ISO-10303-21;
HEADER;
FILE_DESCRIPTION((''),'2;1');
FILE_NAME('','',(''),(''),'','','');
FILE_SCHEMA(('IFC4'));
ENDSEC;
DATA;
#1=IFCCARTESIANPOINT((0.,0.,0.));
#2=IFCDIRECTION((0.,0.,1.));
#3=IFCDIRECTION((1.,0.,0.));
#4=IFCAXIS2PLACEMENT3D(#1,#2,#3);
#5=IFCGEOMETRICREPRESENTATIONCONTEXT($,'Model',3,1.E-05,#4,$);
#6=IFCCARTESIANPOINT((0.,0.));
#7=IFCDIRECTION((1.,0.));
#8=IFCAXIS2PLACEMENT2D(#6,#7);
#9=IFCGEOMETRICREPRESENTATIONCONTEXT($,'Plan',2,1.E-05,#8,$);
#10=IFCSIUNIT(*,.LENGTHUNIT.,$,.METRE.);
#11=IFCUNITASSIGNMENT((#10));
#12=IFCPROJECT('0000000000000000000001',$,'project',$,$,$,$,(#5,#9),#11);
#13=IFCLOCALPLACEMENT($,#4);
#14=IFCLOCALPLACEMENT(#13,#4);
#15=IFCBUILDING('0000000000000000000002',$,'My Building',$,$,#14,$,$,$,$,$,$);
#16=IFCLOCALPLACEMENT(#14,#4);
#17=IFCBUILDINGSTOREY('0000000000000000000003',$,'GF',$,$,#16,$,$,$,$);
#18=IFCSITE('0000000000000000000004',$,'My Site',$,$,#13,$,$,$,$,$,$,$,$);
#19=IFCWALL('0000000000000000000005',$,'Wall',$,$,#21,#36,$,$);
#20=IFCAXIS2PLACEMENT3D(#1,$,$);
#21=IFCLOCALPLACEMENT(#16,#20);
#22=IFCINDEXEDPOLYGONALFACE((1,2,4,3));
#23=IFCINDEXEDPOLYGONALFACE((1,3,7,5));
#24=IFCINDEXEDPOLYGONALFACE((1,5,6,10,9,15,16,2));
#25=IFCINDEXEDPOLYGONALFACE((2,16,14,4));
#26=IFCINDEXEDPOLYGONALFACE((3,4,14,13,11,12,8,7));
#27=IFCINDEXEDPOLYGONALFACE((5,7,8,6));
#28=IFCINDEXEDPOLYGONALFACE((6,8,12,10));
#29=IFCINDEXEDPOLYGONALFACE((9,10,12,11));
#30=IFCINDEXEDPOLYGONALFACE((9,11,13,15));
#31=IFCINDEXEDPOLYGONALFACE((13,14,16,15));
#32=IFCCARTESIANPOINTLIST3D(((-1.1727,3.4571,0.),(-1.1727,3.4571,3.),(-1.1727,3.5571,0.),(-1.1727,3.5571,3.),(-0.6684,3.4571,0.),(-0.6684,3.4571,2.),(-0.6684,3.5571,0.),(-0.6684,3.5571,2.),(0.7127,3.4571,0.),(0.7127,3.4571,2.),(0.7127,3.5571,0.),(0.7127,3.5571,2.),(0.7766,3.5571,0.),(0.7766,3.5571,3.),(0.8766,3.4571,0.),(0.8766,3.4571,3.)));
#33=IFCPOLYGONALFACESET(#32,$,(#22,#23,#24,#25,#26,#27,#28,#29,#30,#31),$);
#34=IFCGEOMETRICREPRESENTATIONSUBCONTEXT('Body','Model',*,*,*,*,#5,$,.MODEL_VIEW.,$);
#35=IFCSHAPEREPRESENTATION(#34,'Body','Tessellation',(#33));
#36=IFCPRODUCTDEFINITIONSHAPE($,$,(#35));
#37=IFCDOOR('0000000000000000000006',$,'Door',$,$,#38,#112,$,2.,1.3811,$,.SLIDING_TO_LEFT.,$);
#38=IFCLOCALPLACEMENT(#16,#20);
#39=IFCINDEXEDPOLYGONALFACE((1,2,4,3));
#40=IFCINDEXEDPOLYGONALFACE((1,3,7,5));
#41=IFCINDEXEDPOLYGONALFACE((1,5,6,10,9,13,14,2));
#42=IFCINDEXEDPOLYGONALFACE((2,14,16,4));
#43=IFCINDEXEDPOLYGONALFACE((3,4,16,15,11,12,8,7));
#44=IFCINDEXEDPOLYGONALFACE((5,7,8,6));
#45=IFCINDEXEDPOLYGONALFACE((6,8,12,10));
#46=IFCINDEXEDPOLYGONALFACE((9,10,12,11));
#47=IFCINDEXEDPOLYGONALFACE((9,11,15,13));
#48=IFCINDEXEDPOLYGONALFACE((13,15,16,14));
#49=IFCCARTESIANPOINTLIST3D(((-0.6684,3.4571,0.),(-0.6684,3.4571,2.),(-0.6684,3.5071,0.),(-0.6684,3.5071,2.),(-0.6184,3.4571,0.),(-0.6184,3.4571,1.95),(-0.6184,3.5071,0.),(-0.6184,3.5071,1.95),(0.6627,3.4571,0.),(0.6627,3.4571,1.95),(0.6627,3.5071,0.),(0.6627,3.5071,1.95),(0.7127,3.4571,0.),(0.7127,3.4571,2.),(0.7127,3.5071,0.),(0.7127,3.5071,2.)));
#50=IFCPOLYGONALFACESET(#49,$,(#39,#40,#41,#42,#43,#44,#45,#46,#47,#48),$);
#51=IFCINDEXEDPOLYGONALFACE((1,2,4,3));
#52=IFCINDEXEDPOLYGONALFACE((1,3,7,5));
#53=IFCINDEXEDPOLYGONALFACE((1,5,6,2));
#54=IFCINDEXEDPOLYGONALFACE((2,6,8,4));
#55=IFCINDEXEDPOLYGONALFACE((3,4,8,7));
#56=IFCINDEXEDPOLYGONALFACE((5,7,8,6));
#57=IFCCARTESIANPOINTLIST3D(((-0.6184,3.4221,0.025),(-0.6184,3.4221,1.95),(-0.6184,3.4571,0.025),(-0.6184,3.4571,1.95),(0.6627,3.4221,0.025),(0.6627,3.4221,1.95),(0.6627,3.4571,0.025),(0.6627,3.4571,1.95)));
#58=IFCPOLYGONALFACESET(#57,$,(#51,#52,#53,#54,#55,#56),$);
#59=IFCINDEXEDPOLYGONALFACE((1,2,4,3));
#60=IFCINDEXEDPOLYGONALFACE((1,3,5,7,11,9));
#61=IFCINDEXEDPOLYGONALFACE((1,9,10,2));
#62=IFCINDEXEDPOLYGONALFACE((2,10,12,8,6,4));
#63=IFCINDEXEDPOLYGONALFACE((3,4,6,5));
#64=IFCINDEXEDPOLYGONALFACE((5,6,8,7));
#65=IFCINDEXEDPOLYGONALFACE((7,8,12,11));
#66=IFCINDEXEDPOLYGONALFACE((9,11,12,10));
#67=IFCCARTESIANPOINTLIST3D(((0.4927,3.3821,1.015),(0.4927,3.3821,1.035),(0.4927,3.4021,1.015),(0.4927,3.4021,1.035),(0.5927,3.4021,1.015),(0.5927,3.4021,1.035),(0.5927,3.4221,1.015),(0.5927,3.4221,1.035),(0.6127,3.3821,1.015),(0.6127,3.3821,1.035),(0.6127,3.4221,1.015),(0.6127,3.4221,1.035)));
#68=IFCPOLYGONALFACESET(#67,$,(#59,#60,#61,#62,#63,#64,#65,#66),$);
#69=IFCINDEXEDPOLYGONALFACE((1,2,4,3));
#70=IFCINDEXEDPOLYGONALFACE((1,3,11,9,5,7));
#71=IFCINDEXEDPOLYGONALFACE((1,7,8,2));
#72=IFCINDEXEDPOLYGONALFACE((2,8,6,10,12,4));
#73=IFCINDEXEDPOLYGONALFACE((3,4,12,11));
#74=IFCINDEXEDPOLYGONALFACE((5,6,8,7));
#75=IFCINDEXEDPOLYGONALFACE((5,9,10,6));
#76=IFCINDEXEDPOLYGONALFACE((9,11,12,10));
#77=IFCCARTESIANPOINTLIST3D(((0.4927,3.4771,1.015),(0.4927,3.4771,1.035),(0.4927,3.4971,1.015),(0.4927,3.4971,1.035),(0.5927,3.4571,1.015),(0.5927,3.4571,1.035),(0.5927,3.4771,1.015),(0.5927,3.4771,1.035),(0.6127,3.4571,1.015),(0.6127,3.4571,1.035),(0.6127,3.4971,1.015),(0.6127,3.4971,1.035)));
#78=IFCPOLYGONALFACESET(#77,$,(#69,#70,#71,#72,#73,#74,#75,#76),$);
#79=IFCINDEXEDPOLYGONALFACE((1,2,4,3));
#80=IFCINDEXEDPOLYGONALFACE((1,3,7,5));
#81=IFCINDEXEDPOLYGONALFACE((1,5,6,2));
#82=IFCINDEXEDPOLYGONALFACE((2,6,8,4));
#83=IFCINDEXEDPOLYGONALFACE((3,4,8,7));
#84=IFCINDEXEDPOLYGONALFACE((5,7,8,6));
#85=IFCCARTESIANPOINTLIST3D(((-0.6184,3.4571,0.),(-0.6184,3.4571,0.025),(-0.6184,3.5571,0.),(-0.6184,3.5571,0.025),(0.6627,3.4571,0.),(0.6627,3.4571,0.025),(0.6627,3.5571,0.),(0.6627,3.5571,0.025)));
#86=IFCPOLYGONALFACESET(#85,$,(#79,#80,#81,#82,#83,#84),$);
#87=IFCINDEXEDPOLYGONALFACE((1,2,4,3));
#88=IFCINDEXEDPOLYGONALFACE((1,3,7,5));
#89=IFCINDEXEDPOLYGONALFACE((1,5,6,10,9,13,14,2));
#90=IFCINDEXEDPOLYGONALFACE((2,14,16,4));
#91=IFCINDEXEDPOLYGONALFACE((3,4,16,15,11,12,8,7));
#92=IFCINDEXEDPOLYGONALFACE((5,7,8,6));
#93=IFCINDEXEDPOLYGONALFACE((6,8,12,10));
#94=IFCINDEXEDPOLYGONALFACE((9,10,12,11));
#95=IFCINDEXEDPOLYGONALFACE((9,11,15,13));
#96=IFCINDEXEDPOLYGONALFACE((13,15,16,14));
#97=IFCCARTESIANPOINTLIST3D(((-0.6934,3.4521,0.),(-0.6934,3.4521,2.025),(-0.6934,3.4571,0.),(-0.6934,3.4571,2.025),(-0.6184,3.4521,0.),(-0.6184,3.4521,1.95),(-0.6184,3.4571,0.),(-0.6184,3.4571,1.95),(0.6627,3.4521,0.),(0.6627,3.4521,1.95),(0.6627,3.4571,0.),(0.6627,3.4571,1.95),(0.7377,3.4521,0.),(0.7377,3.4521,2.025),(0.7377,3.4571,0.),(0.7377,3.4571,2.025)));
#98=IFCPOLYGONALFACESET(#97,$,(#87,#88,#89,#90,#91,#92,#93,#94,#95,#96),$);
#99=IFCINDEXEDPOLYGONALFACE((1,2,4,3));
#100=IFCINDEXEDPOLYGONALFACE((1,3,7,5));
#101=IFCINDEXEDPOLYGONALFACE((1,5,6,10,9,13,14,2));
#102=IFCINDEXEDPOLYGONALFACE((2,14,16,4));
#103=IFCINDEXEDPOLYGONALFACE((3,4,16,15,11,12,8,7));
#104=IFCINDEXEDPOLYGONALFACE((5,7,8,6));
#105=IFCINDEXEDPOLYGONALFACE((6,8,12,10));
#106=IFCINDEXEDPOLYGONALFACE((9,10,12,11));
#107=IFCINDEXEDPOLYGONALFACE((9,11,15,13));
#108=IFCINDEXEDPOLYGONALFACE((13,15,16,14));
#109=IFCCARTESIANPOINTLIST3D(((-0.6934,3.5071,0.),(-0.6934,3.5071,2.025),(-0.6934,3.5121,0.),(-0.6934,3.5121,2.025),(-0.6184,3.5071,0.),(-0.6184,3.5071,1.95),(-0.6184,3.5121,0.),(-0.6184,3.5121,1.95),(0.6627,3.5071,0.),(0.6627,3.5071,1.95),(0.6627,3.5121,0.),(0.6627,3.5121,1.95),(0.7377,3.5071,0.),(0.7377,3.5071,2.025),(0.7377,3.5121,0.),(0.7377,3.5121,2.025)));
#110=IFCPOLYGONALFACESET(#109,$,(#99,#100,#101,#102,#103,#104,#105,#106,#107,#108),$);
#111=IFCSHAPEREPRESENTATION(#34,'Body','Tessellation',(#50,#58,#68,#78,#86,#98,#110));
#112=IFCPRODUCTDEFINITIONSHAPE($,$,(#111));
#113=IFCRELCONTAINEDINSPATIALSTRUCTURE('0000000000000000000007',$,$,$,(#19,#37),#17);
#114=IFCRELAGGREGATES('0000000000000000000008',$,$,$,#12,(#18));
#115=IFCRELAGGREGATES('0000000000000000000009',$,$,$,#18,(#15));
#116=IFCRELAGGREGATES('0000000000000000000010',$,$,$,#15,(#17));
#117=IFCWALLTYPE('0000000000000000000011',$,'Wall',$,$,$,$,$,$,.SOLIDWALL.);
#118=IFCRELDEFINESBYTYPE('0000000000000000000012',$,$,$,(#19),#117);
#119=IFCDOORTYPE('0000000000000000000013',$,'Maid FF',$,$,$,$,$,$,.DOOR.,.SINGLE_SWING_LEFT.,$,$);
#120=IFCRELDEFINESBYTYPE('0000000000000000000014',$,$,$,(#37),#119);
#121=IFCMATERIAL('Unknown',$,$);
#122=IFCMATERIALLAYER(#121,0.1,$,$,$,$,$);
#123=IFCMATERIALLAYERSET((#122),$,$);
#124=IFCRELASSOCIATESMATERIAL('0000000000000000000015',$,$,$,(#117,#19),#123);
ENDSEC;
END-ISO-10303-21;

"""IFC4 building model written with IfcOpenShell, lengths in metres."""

from ifc_helpers import new_model, entity, si_unit, frame, origin_with_axes, origin_2d_with_axis, place, context, subcontext, project, spatial, line, indexed_curve, outline, extrude, shape, source, transform, mapped, material, layer, layer_set, layer_usage, type_object, type_shapes, element, fill, save


model = new_model("IFC4")

# Units and contexts
model_context = context("Model", 3, precision=1e-05, world=origin_with_axes())
plan_context = context("Plan", 2, precision=1e-05, world=origin_2d_with_axis())
body_context_1 = subcontext(model_context, "Body", "Model", "MODEL_VIEW")
body_context_2 = subcontext(plan_context, "Body", "Plan", "PLAN_VIEW")
ifc_project = project(units=[si_unit("LENGTHUNIT", "METRE")], contexts=[model_context, plan_context])

# Site, building, storey
site_placement = place(None, origin_with_axes())
site = spatial("IfcSite", under=ifc_project, at=site_placement, Name="My Site")
building_placement = place(site_placement, origin_with_axes())
building = spatial("IfcBuilding", under=site, at=building_placement, Name="My Building")
storey_placement = place(building_placement, origin_with_axes())
storey = spatial("IfcBuildingStorey", under=building, at=storey_placement, Name="GF")

# Shared definitions
ifc_material = material(Name="Unknown")
ifc_layer = layer(ifc_material, 0.1)
ifc_layer_set = layer_set([ifc_layer])
wall_type = type_object("IfcWallType", Name="Wall", PredefinedType="SOLIDWALL", material=ifc_layer_set)

# Wall, opening, door
ifc_layer_usage_1 = layer_usage(ifc_layer_set, "AXIS2", "POSITIVE", 0.0)
wall_1_placement = place(storey_placement, frame((0.7766, 3.5571, 0.0), z_axis=(0.0, 0.0, 1.0), x_axis=(-1.0, 0.0, 0.0)))
wall_1 = element("IfcWall", 1, at=wall_1_placement, inside=storey, type_object=wall_type, material=ifc_layer_usage_1, Name="Wall", context=body_context_1, shape_type="SweptSolid", body=[
    extrude(outline(indexed_curve([(0.0, 0.0), (-0.1, 0.1), (1.9493, 0.1), (1.9493, 0.0)], segments=[line(1, 2, 3, 4, 1)])), origin_with_axes(), (0.0, 0.0, 1.0), 3.0),
])
shared_shape_1 = source(origin_with_axes(), body_context_1, "Body", "SweptSolid", [
    extrude(outline(indexed_curve([(0.0, 0.0), (1.3811, 0.0), (1.3811, 2.0), (0.0, 2.0)], segments=[line(1, 2, 3, 4, 1)])), frame((0.0, -0.6, 0.0), z_axis=(0.0, -1.0, 0.0), x_axis=(1.0, 0.0, 0.0)), (0.0, 0.0, -1.0), 1.2),
])
opening_1_placement = place(wall_1_placement, frame((1.445, 0.1, 0.0), z_axis=(0.0, 0.0, 1.0), x_axis=(-1.0, 0.000001, 0.0)))
opening_1 = element("IfcOpeningElement", 2, at=opening_1_placement, cuts=wall_1, PredefinedType="OPENING", context=body_context_1, shape_type="MappedRepresentation", body=[
    mapped(shared_shape_1, transform((0.0, 0.0, 0.0), x_axis=(1.0, 0.0, 0.0), y_axis=(0.0, 1.0, 0.0), z_axis=(0.0, 0.0, 1.0), scale=1.0)),
])
door_type_1 = type_object("IfcDoorType", Name="Maid FF", OperationType="SINGLE_SWING_LEFT", PredefinedType="DOOR")
shared_shape_2 = source(origin_with_axes(), body_context_1, "Body", "SweptSolid", [
    extrude(outline(indexed_curve([(0.0, 0.0), (0.0, 2.0), (1.3811, 2.0), (1.3811, 0.0), (1.3311, 0.0), (1.3311, 1.95), (0.05, 1.95), (0.05, 0.0)], segments=[line(1, 2, 3, 4, 5, 6, 7, 8, 1)])), frame((0.0, 0.0, 0.0), z_axis=(0.0, -1.0, 0.0), x_axis=(1.0, 0.0, 0.0)), (0.0, 0.0, -1.0), 0.05),
    extrude(outline(indexed_curve([(0.0, 0.0), (1.2811, 0.0), (1.2811, 0.035), (0.0, 0.035)], segments=[line(1, 2, 3, 4, 1)])), frame((0.05, -0.035, 0.025), z_axis=(0.0, 0.0, 1.0), x_axis=(1.0, 0.0, 0.0)), (0.0, 0.0, 1.0), 1.925),
    extrude(outline(indexed_curve([(0.0, 0.0), (0.0, -0.04), (-0.12, -0.04), (-0.12, -0.02), (-0.02, -0.02), (-0.02, 0.0)], segments=[line(1, 2, 3, 4, 5, 6, 1)])), frame((1.2811, -0.035, 1.015), z_axis=(0.0, 0.0, 1.0), x_axis=(1.0, 0.0, 0.0)), (0.0, 0.0, 1.0), 0.02),
    extrude(outline(indexed_curve([(0.0, 0.0), (0.0, 0.04), (-0.12, 0.04), (-0.12, 0.02), (-0.02, 0.02), (-0.02, 0.0)], segments=[line(1, 2, 3, 4, 5, 6, 1)])), frame((1.2811, 0.0, 1.015), z_axis=(0.0, 0.0, 1.0), x_axis=(1.0, 0.0, 0.0)), (0.0, 0.0, 1.0), 0.02),
    extrude(outline(indexed_curve([(0.0, 0.0), (1.2811, 0.0), (1.2811, 0.1), (0.0, 0.1)], segments=[line(1, 2, 3, 4, 1)])), frame((0.05, 0.0, 0.0), z_axis=(0.0, 0.0, 1.0), x_axis=(1.0, 0.0, 0.0)), (0.0, 0.0, 1.0), 0.025),
    extrude(outline(indexed_curve([(0.0, 0.0), (0.0, 2.025), (1.4311, 2.025), (1.4311, 0.0), (1.3561, 0.0), (1.3561, 1.95), (0.075, 1.95), (0.075, 0.0)], segments=[line(1, 2, 3, 4, 5, 6, 7, 8, 1)])), frame((-0.025, -0.005, 0.0), z_axis=(0.0, -1.0, 0.0), x_axis=(1.0, 0.0, 0.0)), (0.0, 0.0, -1.0), 0.005),
    extrude(outline(indexed_curve([(0.0, 0.0), (0.0, 2.025), (1.4311, 2.025), (1.4311, 0.0), (1.3561, 0.0), (1.3561, 1.95), (0.075, 1.95), (0.075, 0.0)], segments=[line(1, 2, 3, 4, 5, 6, 7, 8, 1)])), frame((-0.025, 0.05, 0.0), z_axis=(0.0, -1.0, 0.0), x_axis=(1.0, 0.0, 0.0)), (0.0, 0.0, -1.0), 0.005),
])
shared_shape_3 = source(origin_with_axes(), body_context_2, "Body", "Curve2D", [
    entity("IfcIndexedPolyCurve", entity("IfcCartesianPointList2D", [[0.0, 0.0], [0.05, 0.0], [0.05, 0.05], [0.0, 0.05]]), [entity("IfcLineIndex", [1, 2, 3, 4, 1])]),
    entity("IfcIndexedPolyCurve", entity("IfcCartesianPointList2D", [[1.3811, 0.0], [1.3311, 0.0], [1.3311, 0.05], [1.3811, 0.05]]), [entity("IfcLineIndex", [1, 2, 3, 4, 1])]),
    entity("IfcIndexedPolyCurve", entity("IfcCartesianPointList2D", [[-0.5906, -0.035], [0.6906, -0.035], [0.6906, 0.0], [-0.5906, 0.0]]), [entity("IfcLineIndex", [1, 2, 3, 4, 1])]),
])
type_shapes(door_type_1, [shared_shape_2, shared_shape_3])
door_1_placement = place(opening_1_placement, frame((0.0, 0.0, 0.0), z_axis=(0.0, 0.0, 1.0), x_axis=(1.0, 0.0, 0.0)))
door_1 = element("IfcDoor", 3, at=door_1_placement, inside=storey, type_object=door_type_1, Name="Door", OperationType="SLIDING_TO_LEFT", OverallHeight=2.0, OverallWidth=1.3811, shapes=[
    shape(body_context_1, "Body", "MappedRepresentation", [mapped(shared_shape_2, transform((0.0, 0.0, 0.0), x_axis=(1.0, 0.0, 0.0), y_axis=(0.0, 1.0, 0.0), z_axis=(0.0, 0.0, 1.0), scale=1.0))]),
    shape(body_context_2, "Body", "MappedRepresentation", [mapped(shared_shape_3, transform((0.0, 0.0, 0.0), x_axis=(1.0, 0.0, 0.0), y_axis=(0.0, 1.0, 0.0), z_axis=(0.0, 0.0, 1.0), scale=1.0))]),
])
fill(opening_1, door_1)

save(model, "model.ifc")
